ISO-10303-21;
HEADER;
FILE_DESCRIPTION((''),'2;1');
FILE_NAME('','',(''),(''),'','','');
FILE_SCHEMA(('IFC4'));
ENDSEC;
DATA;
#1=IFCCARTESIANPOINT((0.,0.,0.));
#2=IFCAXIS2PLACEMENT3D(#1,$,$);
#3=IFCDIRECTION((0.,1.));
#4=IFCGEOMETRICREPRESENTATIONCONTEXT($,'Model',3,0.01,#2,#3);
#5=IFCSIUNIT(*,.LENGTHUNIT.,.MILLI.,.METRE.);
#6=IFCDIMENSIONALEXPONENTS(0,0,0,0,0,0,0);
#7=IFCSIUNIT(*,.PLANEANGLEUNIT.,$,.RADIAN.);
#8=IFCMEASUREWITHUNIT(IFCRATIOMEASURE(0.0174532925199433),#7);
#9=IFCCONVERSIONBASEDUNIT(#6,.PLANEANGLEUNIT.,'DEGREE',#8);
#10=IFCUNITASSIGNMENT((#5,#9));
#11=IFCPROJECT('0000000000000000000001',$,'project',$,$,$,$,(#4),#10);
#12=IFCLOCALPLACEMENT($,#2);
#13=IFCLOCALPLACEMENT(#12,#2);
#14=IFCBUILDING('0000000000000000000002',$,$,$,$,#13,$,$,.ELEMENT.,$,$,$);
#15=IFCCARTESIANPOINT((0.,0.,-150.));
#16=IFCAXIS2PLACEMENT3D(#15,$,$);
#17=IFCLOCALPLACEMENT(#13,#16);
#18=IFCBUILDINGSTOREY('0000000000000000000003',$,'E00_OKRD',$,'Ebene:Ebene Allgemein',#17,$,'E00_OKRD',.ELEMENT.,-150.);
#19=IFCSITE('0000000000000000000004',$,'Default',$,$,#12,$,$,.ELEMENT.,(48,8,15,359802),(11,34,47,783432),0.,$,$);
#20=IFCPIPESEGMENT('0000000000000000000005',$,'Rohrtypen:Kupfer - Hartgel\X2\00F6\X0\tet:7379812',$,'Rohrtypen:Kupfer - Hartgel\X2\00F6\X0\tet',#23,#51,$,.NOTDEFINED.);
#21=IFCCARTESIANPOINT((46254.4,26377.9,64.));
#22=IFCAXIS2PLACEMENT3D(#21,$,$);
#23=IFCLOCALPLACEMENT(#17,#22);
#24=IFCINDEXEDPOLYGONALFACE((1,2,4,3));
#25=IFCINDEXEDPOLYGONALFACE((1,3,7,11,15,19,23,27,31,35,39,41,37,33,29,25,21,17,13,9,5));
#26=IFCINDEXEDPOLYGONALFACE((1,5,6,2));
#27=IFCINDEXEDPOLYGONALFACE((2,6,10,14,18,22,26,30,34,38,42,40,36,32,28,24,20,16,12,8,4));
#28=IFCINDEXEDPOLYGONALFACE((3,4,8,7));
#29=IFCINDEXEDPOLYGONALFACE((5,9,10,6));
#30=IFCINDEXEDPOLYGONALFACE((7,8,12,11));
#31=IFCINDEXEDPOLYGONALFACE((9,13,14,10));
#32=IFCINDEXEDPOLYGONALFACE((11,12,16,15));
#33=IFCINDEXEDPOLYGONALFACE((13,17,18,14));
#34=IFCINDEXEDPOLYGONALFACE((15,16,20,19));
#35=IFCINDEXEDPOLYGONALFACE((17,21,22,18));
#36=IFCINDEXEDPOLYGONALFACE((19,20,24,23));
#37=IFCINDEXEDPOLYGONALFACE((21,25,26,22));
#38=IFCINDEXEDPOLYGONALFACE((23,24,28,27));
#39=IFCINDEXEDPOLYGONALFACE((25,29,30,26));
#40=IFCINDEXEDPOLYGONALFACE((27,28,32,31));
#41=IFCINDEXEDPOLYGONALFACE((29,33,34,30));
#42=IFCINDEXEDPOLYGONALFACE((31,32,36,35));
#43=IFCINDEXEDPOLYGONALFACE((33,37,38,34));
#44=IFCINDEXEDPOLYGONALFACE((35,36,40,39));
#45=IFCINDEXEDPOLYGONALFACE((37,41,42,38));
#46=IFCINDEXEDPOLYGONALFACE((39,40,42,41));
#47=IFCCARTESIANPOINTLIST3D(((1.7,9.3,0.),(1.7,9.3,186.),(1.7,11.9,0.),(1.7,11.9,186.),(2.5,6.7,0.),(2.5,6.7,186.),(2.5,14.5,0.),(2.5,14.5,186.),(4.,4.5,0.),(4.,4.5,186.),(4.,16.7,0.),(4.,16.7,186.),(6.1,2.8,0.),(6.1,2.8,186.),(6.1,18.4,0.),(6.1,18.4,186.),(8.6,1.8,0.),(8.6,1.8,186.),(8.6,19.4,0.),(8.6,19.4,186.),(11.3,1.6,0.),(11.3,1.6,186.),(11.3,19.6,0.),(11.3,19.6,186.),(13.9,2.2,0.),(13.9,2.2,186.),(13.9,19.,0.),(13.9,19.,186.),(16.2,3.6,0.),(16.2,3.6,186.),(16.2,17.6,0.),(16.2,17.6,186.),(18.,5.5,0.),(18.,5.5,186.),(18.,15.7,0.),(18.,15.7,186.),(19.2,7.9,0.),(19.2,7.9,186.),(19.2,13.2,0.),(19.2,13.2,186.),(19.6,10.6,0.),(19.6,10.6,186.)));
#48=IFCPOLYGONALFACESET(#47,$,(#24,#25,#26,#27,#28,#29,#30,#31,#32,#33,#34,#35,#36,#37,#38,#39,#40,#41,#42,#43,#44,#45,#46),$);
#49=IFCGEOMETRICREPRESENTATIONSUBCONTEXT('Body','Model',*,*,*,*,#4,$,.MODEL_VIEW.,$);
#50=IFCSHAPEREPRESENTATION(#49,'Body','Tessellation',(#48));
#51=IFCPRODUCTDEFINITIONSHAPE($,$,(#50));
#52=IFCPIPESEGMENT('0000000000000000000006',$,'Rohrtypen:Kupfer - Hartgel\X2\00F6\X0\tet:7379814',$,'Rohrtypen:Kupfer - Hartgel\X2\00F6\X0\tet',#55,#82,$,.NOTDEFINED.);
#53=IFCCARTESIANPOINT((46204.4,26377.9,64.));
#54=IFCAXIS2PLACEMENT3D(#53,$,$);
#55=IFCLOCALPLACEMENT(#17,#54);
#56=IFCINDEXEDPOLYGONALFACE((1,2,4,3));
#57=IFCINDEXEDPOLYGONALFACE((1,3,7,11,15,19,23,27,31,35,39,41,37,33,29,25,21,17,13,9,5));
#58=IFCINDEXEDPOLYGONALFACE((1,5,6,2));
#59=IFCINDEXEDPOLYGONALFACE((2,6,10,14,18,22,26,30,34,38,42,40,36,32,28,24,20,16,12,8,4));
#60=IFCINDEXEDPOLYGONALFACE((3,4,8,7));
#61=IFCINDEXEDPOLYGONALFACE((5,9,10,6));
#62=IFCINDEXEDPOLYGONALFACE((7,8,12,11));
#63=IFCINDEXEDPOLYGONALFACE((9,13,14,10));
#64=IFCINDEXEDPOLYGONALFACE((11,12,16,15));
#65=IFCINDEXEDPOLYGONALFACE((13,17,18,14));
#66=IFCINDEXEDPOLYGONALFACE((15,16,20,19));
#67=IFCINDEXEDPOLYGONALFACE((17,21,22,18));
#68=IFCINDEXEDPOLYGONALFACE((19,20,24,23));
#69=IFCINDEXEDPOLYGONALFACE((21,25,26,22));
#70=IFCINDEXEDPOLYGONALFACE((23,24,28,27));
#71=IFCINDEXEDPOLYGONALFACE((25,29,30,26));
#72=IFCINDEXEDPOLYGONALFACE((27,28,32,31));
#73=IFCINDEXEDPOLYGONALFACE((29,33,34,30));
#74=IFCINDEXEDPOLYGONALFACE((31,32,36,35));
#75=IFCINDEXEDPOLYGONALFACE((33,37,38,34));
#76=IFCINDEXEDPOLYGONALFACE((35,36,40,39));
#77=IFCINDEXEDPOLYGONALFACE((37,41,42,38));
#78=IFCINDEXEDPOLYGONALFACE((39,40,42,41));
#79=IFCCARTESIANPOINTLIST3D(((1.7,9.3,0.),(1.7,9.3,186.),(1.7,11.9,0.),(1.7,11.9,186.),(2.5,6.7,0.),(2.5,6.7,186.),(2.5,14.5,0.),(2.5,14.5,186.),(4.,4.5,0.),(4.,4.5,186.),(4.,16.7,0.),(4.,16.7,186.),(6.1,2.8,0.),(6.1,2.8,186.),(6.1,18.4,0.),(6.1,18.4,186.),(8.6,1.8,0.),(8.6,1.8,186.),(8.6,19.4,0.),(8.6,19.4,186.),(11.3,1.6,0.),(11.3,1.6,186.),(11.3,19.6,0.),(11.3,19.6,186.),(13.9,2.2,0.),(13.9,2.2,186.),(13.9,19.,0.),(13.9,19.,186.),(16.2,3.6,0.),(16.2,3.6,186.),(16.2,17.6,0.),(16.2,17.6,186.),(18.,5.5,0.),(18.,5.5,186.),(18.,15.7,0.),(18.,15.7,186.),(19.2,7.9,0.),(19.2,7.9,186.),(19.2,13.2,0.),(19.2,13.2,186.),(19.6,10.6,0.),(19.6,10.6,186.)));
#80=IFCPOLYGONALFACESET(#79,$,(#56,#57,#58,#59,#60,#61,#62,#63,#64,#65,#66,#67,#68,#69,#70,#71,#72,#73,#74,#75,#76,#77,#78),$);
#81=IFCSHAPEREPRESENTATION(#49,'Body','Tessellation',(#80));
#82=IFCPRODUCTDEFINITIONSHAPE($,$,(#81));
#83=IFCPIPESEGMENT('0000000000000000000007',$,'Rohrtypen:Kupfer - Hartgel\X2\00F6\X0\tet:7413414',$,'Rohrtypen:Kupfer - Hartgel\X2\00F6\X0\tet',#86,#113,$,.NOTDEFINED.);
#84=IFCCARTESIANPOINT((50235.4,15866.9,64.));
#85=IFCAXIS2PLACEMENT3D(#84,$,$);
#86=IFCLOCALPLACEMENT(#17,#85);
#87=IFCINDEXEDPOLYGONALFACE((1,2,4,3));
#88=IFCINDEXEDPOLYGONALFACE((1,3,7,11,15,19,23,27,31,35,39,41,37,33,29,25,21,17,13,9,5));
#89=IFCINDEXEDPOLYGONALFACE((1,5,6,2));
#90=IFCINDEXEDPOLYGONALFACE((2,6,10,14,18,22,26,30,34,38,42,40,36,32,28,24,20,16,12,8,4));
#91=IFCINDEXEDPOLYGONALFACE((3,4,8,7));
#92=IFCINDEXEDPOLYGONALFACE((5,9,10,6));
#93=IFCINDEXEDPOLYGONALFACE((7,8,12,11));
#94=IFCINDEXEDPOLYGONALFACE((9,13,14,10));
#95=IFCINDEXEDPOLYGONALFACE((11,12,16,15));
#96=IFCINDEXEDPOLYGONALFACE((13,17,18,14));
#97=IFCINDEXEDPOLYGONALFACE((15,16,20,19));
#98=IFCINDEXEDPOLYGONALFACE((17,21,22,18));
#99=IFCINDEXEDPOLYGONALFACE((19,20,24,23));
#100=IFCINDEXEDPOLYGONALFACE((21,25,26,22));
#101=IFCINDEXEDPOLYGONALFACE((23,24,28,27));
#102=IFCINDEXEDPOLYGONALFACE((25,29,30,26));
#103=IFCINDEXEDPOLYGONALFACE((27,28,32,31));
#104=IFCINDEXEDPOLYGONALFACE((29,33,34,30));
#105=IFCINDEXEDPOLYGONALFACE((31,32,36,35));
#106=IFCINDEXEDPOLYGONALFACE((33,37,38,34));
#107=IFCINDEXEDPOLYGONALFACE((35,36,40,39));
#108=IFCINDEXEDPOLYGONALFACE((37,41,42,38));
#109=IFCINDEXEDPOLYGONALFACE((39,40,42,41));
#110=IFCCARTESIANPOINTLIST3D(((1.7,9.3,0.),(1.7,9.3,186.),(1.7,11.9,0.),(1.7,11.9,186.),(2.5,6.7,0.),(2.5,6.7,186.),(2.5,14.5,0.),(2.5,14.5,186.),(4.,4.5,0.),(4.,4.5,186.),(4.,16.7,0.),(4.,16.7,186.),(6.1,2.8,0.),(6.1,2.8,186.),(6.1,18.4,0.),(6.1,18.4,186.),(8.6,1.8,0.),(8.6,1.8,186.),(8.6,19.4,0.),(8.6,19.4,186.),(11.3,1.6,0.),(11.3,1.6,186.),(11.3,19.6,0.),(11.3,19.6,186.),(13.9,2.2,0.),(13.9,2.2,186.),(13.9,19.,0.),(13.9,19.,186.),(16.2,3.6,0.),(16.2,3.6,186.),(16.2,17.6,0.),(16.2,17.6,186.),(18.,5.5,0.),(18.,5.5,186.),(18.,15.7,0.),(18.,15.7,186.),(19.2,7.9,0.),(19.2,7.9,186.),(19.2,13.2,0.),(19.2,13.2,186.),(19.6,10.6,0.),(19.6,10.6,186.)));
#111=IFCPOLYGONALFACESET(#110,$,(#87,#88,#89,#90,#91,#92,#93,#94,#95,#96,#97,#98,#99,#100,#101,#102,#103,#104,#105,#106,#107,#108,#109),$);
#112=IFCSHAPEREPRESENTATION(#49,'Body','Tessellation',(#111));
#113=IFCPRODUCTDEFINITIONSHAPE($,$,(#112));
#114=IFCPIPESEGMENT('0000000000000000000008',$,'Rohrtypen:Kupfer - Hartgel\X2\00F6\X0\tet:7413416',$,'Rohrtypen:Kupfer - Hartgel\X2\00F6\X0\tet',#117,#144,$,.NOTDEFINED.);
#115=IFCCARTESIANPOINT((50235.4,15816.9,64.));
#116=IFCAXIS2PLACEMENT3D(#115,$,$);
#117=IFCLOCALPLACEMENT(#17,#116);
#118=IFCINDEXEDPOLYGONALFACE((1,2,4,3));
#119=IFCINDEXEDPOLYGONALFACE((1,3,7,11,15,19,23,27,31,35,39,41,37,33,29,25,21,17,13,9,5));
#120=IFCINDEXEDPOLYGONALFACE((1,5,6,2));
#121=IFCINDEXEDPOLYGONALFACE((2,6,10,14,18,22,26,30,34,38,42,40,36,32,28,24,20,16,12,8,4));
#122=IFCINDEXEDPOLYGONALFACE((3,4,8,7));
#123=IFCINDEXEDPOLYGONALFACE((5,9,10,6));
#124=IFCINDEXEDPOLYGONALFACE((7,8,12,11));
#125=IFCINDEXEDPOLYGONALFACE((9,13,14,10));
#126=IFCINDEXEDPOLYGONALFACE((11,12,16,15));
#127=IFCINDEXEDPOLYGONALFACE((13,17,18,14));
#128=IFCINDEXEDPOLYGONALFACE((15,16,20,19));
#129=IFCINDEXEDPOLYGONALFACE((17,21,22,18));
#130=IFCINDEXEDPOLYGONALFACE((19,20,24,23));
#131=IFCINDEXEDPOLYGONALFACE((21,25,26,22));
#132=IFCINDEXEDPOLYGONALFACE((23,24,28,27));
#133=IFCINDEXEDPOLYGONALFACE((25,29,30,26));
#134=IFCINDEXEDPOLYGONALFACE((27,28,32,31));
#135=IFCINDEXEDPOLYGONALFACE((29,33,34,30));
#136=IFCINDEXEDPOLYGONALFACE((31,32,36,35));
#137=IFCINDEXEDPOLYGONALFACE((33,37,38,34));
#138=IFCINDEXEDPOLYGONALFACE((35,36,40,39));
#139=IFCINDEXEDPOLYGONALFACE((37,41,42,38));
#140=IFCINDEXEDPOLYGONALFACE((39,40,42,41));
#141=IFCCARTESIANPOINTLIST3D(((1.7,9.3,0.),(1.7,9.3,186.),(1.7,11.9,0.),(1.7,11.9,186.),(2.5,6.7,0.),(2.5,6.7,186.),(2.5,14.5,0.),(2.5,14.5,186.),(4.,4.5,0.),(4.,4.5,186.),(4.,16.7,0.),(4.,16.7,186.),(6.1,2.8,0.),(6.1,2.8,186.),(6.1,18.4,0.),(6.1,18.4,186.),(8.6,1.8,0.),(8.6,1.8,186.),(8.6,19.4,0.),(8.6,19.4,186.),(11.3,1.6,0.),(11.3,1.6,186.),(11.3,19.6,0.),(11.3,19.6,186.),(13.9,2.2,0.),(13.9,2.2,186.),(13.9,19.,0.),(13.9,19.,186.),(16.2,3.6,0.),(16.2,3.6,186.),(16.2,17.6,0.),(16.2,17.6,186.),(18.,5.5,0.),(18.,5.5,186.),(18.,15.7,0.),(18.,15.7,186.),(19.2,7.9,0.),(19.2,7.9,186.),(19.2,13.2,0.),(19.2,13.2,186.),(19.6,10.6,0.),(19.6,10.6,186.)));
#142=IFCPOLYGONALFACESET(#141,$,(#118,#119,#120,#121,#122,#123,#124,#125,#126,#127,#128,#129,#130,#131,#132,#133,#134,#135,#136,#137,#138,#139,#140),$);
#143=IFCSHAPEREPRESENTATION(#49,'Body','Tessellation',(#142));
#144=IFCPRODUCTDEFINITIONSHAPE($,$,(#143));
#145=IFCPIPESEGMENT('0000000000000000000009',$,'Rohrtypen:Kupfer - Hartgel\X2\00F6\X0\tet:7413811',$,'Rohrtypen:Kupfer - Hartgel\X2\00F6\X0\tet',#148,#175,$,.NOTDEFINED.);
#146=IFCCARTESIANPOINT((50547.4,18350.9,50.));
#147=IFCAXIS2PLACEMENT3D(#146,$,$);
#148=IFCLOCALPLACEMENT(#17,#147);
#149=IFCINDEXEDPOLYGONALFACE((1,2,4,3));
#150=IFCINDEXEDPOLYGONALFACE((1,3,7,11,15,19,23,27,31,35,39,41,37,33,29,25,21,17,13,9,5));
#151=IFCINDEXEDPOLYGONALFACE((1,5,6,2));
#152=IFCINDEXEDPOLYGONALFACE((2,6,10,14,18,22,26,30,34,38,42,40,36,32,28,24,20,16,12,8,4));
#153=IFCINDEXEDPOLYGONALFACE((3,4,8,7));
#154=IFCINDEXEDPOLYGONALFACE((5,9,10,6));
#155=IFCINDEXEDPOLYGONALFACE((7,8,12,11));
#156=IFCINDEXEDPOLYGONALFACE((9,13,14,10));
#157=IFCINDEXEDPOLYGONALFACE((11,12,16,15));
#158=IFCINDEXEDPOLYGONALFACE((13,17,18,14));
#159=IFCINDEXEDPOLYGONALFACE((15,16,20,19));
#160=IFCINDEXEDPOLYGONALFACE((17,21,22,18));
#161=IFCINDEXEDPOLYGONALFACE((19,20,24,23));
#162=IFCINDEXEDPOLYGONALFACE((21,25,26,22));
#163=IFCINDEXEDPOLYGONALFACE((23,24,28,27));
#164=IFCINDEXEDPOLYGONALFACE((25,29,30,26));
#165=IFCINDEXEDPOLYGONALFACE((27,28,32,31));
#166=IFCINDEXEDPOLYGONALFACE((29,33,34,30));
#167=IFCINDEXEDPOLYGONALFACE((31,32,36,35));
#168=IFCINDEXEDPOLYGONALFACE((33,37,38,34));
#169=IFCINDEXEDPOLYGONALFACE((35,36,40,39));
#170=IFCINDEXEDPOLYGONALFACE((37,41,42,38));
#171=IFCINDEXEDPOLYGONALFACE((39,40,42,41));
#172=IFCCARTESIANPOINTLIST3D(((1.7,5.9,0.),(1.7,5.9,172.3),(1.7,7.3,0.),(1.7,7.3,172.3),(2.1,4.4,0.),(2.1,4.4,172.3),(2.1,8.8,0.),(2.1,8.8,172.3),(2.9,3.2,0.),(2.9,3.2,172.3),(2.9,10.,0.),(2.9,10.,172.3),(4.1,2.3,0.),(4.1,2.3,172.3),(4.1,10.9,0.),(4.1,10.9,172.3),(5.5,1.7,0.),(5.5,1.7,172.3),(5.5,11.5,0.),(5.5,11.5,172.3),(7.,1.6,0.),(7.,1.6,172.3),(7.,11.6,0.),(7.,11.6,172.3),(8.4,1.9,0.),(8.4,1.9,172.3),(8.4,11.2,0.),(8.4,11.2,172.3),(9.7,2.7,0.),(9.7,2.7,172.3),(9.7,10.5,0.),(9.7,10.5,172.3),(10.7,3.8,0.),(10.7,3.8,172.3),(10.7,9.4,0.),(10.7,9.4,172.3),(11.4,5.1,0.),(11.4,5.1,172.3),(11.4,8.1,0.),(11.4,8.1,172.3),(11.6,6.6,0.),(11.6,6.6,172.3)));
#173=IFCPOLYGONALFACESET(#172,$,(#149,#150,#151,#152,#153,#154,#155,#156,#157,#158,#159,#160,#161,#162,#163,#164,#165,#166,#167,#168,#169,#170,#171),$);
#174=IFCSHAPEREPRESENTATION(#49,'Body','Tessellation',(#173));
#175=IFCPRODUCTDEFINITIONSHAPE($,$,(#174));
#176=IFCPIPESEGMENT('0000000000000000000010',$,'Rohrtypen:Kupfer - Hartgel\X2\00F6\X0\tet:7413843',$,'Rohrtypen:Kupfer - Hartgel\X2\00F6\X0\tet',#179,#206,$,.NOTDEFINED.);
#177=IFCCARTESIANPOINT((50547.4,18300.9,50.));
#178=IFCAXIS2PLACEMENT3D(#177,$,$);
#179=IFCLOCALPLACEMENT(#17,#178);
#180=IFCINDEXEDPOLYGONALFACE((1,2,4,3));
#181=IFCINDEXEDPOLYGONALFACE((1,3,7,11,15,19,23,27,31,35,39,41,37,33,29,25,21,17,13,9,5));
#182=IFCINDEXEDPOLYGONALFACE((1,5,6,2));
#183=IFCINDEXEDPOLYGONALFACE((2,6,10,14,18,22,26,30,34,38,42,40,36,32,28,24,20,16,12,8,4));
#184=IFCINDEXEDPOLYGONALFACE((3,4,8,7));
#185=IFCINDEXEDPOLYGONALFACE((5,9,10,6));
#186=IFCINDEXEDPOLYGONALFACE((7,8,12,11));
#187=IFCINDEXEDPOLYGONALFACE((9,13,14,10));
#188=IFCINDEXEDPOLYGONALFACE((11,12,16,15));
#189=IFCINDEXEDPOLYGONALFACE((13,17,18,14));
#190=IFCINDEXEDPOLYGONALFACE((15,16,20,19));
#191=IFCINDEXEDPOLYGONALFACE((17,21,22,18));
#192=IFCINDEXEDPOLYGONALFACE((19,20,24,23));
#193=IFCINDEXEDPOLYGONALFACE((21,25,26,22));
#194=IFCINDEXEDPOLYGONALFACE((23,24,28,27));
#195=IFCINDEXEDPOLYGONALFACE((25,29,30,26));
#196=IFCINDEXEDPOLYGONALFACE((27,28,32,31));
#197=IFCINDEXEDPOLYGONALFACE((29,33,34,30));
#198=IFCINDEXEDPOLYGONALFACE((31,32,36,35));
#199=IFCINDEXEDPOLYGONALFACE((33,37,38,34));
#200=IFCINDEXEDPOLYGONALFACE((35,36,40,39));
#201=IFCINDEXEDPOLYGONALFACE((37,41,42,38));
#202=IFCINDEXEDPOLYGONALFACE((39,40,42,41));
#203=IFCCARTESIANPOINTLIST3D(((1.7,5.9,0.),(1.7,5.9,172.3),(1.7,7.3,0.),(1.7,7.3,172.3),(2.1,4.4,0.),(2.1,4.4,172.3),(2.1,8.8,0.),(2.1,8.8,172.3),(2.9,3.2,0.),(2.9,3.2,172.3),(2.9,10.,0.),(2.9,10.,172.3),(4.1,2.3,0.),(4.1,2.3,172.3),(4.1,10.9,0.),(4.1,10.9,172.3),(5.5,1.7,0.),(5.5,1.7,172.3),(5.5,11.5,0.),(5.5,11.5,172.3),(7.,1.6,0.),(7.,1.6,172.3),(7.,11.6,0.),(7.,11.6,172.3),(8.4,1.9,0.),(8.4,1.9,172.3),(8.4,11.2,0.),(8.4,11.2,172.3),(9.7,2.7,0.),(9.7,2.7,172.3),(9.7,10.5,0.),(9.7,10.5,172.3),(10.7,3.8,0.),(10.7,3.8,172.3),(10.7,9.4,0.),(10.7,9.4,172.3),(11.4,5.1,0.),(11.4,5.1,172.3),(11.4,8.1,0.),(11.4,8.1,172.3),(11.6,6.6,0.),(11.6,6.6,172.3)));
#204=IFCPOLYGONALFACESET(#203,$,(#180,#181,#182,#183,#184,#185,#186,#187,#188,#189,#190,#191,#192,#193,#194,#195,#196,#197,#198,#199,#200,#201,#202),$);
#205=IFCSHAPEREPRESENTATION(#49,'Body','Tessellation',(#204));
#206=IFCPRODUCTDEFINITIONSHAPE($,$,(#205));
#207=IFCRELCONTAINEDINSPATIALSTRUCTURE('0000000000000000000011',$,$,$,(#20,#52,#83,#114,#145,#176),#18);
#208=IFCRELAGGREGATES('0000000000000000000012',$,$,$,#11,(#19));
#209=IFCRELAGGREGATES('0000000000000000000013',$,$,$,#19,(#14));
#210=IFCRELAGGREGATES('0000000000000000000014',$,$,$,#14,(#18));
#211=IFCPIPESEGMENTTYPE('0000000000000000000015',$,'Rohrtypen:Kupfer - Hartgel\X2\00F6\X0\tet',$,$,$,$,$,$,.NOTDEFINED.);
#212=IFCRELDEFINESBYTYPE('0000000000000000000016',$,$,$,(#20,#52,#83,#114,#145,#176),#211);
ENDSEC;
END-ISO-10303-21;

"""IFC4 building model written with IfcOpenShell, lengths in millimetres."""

from ifc_helpers import new_model, entity, si_unit, converted_unit, direction, frame, frame_2d, origin, origin_2d_with_axis, place, context, subcontext, project, spatial, circle, extrude, type_object, element, save


model = new_model("IFC4")

# Units and contexts
model_context = context("Model", 3, precision=0.01, world=origin(), true_north=direction((0.0, 1.0)))
body_context = subcontext(model_context, "Body", "Model", "MODEL_VIEW")
ifc_project = project(units=[si_unit("LENGTHUNIT", "METRE", prefix="MILLI"), converted_unit("PLANEANGLEUNIT", "DEGREE", entity("IfcRatioMeasure", 0.0174532925199433), si_unit("PLANEANGLEUNIT", "RADIAN"), dimensions=[0, 0, 0, 0, 0, 0, 0])], contexts=[model_context])

# Site, building, storey
site_placement = place(None, origin())
site = spatial("IfcSite", under=ifc_project, at=site_placement, Name="Default", CompositionType="ELEMENT", RefLatitude=(48, 8, 15, 359802), RefLongitude=(11, 34, 47, 783432), RefElevation=0.0)
building_placement = place(site_placement, origin())
building = spatial("IfcBuilding", under=site, at=building_placement, CompositionType="ELEMENT")
storey_placement = place(building_placement, frame((0.0, 0.0, -150.0)))
storey = spatial("IfcBuildingStorey", under=building, at=storey_placement, Name="E00_OKRD", ObjectType="Ebene:Ebene Allgemein", LongName="E00_OKRD", CompositionType="ELEMENT", Elevation=-150.0)

# Pipe segments
pipe_segment_type = type_object("IfcPipeSegmentType", Name="Rohrtypen:Kupfer - Hartgelötet", PredefinedType="NOTDEFINED")
pipe_segment_1_placement = place(storey_placement, frame((46254.4, 26377.9, 64.0)))
element("IfcPipeSegment", 1, at=pipe_segment_1_placement, inside=storey, type_object=pipe_segment_type, Name="Rohrtypen:Kupfer - Hartgelötet:7379812", ObjectType="Rohrtypen:Kupfer - Hartgelötet", PredefinedType="NOTDEFINED", context=body_context, shape_type="SweptSolid", body=[
    extrude(circle(Radius=9.0, at=origin_2d_with_axis()), frame((10.6, 10.6, 0.0)), (0.0, 0.0, 1.0), 186.0),
])
pipe_segment_2_placement = place(storey_placement, frame((46204.4, 26377.9, 64.0)))
element("IfcPipeSegment", 2, at=pipe_segment_2_placement, inside=storey, type_object=pipe_segment_type, Name="Rohrtypen:Kupfer - Hartgelötet:7379814", ObjectType="Rohrtypen:Kupfer - Hartgelötet", PredefinedType="NOTDEFINED", context=body_context, shape_type="SweptSolid", body=[
    extrude(circle(Radius=9.0, at=origin_2d_with_axis()), frame((10.6, 10.6, 0.0)), (0.0, 0.0, 1.0), 186.0),
])
pipe_segment_3_placement = place(storey_placement, frame((50235.4, 15866.9, 64.0)))
element("IfcPipeSegment", 3, at=pipe_segment_3_placement, inside=storey, type_object=pipe_segment_type, Name="Rohrtypen:Kupfer - Hartgelötet:7413414", ObjectType="Rohrtypen:Kupfer - Hartgelötet", PredefinedType="NOTDEFINED", context=body_context, shape_type="SweptSolid", body=[
    extrude(circle(Radius=9.0, at=origin_2d_with_axis()), frame((10.6, 10.6, 0.0)), (0.0, 0.0, 1.0), 186.0),
])
pipe_segment_4_placement = place(storey_placement, frame((50235.4, 15816.9, 64.0)))
element("IfcPipeSegment", 4, at=pipe_segment_4_placement, inside=storey, type_object=pipe_segment_type, Name="Rohrtypen:Kupfer - Hartgelötet:7413416", ObjectType="Rohrtypen:Kupfer - Hartgelötet", PredefinedType="NOTDEFINED", context=body_context, shape_type="SweptSolid", body=[
    extrude(circle(Radius=9.0, at=frame_2d((0.0, 0.0), x_axis=(1.0, 0.0))), frame((10.6, 10.6, 0.0)), (0.0, 0.0, 1.0), 186.0),
])
pipe_segment_5_placement = place(storey_placement, frame((50547.4, 18350.9, 50.0)))
element("IfcPipeSegment", 5, at=pipe_segment_5_placement, inside=storey, type_object=pipe_segment_type, Name="Rohrtypen:Kupfer - Hartgelötet:7413811", ObjectType="Rohrtypen:Kupfer - Hartgelötet", PredefinedType="NOTDEFINED", context=body_context, shape_type="SweptSolid", body=[
    extrude(circle(Radius=5.0, at=origin_2d_with_axis()), frame((6.6, 6.6, 0.0)), (0.0, 0.0, 1.0), 172.3),
])
pipe_segment_6_placement = place(storey_placement, frame((50547.4, 18300.9, 50.0)))
element("IfcPipeSegment", 6, at=pipe_segment_6_placement, inside=storey, type_object=pipe_segment_type, Name="Rohrtypen:Kupfer - Hartgelötet:7413843", ObjectType="Rohrtypen:Kupfer - Hartgelötet", PredefinedType="NOTDEFINED", context=body_context, shape_type="SweptSolid", body=[
    extrude(circle(Radius=5.0, at=origin_2d_with_axis()), frame((6.6, 6.6, 0.0)), (0.0, 0.0, 1.0), 172.3),
])

save(model, "model.ifc")
